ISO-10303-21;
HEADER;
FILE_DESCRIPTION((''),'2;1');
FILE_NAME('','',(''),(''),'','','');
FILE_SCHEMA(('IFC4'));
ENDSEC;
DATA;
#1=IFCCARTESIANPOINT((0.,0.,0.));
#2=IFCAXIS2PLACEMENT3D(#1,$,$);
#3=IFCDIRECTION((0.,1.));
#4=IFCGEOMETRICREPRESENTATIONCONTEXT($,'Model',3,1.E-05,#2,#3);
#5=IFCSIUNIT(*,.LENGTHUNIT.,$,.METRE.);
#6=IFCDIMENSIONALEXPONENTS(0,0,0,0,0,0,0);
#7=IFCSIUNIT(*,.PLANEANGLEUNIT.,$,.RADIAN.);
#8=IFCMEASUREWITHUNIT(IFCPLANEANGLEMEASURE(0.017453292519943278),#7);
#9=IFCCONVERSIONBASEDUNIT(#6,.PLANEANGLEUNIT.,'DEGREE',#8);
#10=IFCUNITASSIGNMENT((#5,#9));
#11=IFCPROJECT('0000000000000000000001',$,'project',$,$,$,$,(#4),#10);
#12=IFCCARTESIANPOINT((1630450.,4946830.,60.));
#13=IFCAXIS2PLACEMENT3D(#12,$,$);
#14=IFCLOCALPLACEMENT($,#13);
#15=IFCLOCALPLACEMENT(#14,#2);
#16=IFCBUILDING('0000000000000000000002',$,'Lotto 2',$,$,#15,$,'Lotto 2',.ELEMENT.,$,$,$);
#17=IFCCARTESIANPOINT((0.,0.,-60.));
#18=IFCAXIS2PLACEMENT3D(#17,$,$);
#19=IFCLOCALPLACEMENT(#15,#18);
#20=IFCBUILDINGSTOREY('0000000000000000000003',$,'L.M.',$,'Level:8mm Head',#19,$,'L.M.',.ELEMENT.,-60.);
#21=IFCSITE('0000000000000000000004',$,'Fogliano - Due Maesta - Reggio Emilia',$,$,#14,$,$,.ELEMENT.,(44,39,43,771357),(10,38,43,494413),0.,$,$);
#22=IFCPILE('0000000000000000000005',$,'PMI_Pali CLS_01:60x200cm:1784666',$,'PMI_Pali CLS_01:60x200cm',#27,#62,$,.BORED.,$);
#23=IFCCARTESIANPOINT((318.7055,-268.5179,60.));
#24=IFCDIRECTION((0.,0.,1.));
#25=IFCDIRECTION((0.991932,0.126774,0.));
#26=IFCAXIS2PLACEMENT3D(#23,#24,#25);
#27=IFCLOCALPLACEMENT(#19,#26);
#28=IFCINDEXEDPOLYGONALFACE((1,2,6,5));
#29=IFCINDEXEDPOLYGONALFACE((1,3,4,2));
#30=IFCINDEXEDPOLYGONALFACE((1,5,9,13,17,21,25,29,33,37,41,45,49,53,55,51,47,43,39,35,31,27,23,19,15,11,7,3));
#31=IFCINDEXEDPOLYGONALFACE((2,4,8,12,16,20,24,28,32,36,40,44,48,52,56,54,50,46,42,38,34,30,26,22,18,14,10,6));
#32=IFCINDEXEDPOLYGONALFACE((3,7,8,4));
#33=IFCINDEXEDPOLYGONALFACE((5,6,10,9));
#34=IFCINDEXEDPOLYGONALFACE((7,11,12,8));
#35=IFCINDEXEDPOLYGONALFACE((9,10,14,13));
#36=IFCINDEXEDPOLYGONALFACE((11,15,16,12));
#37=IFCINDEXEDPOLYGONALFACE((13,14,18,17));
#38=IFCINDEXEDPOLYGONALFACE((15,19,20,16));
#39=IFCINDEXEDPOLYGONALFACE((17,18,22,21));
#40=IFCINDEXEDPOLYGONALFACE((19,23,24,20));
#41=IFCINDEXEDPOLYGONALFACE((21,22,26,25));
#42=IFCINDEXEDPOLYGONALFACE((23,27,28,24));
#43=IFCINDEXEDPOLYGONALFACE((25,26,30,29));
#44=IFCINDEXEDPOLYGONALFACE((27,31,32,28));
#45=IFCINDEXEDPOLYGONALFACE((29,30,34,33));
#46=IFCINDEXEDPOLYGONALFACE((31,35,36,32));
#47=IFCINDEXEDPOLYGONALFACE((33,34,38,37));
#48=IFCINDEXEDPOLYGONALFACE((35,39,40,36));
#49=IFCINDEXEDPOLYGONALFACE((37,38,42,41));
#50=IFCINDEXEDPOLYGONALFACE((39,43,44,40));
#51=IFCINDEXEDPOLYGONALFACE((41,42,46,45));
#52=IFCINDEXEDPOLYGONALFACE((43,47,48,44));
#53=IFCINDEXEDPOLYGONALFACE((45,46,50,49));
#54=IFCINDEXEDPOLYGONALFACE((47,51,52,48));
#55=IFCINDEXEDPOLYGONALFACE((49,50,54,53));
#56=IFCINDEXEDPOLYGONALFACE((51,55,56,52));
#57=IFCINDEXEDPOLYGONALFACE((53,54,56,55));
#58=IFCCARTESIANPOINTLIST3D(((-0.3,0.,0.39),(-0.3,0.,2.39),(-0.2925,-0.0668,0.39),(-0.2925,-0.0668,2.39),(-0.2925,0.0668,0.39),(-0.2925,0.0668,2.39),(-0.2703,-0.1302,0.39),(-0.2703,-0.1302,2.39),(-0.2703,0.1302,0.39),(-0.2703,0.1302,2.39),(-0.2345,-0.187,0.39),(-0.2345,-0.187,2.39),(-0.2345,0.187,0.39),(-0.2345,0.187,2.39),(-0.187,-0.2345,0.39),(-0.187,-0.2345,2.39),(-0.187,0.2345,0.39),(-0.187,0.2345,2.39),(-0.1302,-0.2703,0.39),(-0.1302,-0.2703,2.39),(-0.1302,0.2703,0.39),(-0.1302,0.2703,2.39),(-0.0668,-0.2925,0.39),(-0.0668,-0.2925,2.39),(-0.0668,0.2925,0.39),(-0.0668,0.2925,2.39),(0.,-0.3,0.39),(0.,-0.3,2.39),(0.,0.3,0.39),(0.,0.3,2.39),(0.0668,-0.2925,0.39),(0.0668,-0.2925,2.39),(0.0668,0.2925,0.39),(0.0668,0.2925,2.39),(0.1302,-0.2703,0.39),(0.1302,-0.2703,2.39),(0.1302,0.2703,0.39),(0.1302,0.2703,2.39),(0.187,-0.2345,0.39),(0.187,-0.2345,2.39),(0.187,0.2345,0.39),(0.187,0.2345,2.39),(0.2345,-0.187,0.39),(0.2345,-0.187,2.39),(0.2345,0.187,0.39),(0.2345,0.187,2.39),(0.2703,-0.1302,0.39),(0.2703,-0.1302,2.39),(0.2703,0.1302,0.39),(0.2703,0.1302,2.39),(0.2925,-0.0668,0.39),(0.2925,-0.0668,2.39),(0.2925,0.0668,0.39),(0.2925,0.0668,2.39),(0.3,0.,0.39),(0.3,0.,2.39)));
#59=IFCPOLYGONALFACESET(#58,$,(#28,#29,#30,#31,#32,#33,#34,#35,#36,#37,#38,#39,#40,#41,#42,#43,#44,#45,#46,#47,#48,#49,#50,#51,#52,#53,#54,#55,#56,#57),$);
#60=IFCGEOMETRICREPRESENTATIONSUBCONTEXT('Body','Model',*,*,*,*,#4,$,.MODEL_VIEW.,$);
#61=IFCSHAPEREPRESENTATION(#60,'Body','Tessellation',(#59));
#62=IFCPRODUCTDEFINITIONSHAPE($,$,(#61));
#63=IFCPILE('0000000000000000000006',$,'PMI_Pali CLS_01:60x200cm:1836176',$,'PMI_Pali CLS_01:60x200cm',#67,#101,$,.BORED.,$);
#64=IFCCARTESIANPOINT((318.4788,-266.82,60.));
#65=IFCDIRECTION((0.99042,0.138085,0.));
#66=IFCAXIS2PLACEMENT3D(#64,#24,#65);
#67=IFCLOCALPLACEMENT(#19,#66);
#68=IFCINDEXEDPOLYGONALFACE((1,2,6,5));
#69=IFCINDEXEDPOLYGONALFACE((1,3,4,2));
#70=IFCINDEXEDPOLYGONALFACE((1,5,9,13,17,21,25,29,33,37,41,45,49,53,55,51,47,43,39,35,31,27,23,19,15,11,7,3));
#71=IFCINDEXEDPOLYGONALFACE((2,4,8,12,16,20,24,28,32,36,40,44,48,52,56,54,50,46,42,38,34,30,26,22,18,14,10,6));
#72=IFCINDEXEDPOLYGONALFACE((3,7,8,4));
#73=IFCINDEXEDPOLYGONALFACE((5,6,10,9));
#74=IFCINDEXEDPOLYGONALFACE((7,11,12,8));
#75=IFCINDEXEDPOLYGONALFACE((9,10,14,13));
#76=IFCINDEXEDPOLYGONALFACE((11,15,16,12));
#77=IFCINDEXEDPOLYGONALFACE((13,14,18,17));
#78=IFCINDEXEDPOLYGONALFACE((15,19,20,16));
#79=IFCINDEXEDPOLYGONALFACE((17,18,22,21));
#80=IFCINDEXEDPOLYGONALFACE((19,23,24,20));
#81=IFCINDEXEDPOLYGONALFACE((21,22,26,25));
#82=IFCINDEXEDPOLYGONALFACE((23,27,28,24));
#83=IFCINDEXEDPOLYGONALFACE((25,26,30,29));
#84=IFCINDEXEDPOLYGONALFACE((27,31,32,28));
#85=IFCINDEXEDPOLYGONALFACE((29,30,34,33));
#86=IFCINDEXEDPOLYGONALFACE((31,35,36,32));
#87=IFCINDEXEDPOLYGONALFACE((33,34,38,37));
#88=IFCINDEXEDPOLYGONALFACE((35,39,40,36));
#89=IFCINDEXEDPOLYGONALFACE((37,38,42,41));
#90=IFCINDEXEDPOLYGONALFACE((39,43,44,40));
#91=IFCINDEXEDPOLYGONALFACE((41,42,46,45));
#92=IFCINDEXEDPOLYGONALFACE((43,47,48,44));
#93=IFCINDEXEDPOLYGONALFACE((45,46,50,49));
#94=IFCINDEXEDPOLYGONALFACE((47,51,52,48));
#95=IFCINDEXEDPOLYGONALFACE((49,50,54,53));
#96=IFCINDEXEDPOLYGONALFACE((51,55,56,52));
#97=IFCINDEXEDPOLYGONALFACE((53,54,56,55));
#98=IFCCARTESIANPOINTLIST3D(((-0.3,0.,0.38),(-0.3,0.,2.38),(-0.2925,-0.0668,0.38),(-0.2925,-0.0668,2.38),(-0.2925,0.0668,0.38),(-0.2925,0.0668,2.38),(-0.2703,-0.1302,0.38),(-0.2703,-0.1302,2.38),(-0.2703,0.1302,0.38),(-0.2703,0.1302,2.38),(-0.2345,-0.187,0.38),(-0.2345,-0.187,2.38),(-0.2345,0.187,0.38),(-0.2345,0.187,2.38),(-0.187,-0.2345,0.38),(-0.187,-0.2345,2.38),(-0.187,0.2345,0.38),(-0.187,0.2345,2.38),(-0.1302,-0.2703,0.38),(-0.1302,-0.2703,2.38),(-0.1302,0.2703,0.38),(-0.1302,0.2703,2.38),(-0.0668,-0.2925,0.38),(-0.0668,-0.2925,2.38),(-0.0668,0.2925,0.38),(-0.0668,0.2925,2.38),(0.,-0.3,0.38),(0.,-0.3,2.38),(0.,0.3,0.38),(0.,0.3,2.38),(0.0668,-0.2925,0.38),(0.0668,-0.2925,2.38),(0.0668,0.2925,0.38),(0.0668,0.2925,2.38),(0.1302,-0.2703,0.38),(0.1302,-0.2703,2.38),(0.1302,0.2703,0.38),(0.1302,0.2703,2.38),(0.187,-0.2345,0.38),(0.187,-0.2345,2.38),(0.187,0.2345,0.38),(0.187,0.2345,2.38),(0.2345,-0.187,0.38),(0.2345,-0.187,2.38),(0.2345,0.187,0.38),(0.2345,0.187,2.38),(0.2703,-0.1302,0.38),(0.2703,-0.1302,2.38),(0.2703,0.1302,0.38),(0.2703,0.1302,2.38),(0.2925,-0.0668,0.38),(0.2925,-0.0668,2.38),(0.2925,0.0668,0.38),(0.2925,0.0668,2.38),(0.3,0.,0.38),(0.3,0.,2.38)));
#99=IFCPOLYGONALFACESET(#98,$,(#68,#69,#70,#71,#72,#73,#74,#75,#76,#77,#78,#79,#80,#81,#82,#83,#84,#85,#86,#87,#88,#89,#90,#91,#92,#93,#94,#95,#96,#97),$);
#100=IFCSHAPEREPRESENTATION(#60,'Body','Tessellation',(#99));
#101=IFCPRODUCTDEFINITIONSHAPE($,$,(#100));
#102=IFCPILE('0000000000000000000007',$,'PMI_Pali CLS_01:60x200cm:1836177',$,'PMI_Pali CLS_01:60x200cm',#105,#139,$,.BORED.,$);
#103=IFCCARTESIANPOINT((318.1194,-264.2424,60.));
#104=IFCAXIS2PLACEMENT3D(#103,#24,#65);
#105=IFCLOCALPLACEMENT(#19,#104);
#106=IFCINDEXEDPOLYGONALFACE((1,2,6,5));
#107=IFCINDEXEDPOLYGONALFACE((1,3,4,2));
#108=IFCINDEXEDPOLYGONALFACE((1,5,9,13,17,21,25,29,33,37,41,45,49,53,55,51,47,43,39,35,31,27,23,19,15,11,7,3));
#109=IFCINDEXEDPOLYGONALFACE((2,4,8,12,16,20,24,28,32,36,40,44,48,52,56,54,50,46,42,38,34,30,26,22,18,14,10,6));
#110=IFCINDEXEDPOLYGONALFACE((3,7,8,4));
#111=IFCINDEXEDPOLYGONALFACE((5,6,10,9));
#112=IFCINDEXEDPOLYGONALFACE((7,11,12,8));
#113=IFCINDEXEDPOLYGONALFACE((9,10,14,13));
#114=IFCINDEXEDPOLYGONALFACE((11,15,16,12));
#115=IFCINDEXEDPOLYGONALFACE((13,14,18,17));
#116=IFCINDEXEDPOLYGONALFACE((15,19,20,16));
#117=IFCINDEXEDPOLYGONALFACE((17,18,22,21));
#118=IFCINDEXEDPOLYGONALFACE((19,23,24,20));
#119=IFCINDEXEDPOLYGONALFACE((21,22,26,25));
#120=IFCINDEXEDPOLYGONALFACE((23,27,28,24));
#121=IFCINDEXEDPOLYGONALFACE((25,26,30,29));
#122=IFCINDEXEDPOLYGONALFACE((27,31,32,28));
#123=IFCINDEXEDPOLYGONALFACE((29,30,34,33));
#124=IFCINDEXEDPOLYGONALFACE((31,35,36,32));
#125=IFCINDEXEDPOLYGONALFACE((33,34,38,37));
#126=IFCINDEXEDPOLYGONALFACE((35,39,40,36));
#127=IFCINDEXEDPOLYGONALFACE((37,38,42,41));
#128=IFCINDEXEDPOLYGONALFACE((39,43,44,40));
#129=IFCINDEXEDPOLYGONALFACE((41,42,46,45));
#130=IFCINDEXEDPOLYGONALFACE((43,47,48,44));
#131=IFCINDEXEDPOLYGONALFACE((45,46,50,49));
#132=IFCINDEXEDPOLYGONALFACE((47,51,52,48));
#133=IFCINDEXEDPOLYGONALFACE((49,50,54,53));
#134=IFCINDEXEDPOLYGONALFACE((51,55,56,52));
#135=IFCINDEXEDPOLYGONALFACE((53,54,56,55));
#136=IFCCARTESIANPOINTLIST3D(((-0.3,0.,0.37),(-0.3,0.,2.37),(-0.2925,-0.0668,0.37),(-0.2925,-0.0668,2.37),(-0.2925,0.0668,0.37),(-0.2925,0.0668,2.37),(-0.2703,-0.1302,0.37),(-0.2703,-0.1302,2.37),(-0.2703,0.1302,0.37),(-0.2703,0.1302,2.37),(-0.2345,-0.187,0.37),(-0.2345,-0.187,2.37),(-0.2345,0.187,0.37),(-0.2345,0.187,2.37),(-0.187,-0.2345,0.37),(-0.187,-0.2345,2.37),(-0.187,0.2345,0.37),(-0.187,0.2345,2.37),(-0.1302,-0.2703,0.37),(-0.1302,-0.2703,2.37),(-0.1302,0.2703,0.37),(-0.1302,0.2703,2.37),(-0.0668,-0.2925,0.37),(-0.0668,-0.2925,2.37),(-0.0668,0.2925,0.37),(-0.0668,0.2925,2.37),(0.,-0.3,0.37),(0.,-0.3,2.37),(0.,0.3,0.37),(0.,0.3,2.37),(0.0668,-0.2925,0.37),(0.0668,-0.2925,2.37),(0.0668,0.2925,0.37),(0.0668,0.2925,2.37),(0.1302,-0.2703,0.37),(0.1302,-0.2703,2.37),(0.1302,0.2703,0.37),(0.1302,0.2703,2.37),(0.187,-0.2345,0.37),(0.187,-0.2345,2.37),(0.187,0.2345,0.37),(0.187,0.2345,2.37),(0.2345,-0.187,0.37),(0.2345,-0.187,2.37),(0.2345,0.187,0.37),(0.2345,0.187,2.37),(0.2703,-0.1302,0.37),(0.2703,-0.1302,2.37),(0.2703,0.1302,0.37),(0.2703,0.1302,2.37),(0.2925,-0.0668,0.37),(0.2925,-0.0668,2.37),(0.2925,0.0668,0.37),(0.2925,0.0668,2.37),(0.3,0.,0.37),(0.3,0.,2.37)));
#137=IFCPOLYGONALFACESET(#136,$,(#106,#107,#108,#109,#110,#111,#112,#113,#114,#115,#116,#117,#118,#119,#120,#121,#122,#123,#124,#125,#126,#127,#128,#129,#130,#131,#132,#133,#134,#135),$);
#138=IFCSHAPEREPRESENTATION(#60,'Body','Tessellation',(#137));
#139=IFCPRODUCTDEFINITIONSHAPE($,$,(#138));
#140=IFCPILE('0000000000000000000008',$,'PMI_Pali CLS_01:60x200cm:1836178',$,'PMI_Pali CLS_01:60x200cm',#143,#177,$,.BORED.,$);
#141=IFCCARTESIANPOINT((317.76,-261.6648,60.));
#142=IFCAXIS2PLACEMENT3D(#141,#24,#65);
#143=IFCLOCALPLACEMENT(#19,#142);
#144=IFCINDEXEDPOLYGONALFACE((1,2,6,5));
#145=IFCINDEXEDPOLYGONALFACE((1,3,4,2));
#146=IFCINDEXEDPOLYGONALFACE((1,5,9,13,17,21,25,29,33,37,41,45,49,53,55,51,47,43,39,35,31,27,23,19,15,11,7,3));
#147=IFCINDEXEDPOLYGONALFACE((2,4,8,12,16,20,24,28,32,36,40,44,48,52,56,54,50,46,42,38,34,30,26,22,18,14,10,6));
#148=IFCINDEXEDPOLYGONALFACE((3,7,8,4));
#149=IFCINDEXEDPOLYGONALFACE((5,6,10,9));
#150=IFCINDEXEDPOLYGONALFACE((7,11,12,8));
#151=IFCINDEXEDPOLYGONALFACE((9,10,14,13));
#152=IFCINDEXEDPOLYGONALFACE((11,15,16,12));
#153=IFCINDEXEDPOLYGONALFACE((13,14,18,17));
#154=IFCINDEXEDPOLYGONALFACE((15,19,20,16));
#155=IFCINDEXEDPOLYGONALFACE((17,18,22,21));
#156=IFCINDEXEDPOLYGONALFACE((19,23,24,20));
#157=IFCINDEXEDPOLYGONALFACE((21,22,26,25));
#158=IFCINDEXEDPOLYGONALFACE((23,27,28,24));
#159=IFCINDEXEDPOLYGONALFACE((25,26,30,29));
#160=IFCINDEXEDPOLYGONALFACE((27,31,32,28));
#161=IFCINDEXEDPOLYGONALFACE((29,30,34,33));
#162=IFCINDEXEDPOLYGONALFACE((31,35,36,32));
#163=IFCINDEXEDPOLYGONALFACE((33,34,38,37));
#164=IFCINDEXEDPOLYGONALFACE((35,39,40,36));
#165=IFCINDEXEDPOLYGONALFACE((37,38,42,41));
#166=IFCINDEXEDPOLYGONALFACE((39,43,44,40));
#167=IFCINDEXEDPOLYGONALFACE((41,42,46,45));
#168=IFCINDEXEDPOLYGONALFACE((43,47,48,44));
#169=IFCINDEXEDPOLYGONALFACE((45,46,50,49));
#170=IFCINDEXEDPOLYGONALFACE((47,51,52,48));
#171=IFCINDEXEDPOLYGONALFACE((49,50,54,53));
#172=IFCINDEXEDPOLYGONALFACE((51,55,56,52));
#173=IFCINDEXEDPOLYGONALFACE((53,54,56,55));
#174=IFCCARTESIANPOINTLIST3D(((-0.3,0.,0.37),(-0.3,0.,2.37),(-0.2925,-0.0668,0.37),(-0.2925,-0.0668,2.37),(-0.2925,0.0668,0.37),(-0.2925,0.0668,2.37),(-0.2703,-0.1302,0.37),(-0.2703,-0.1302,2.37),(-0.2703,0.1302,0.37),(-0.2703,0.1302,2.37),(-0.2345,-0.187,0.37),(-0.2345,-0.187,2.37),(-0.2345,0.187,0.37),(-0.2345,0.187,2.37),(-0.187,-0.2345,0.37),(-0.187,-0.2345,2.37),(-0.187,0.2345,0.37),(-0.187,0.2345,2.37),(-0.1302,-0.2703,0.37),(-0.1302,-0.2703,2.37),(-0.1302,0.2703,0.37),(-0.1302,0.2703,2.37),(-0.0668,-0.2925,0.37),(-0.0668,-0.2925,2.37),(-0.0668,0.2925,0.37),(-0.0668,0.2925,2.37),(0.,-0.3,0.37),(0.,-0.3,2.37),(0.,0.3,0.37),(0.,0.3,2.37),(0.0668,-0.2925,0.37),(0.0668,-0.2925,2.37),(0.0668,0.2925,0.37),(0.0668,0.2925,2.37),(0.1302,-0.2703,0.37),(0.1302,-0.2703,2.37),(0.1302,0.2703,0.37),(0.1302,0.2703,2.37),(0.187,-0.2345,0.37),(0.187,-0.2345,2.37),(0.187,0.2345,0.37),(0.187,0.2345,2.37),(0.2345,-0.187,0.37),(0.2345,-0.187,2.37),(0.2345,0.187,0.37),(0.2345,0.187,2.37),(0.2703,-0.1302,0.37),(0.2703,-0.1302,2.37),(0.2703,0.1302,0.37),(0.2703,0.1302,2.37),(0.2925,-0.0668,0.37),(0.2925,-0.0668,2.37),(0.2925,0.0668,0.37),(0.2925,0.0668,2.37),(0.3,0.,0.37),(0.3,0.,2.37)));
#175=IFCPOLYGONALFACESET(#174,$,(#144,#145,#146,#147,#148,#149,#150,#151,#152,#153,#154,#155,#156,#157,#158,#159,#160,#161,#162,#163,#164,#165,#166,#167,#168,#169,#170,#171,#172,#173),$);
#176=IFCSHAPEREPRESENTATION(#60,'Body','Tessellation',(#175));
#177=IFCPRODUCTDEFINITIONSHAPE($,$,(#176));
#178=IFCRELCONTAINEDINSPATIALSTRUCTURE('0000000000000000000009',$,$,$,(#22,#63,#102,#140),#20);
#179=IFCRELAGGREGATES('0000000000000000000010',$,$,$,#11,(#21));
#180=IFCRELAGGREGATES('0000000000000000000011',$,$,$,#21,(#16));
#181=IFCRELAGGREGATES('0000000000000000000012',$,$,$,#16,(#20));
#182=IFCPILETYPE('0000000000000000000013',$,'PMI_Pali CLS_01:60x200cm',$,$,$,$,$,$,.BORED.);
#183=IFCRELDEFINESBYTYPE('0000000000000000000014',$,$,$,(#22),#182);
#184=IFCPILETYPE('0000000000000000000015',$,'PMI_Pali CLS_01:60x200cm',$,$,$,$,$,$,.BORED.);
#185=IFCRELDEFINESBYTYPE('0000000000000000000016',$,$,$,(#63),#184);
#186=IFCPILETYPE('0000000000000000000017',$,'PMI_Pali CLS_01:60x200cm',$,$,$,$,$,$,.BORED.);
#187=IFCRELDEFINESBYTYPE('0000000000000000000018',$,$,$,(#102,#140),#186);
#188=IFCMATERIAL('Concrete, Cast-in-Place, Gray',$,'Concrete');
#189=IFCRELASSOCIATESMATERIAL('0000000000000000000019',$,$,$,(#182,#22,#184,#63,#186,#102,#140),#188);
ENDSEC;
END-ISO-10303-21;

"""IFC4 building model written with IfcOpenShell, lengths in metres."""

from ifc_helpers import new_model, entity, si_unit, converted_unit, direction, frame, origin, place, context, subcontext, project, spatial, arc, indexed_curve, outline, extrude, source, transform, mapped, material, type_object, type_shapes, element, save


model = new_model("IFC4")

# Units and contexts
model_context = context("Model", 3, precision=1e-05, world=origin(), true_north=direction((0.0, 1.0)))
body_context = subcontext(model_context, "Body", "Model", "MODEL_VIEW")
ifc_project = project(units=[si_unit("LENGTHUNIT", "METRE"), converted_unit("PLANEANGLEUNIT", "DEGREE", entity("IfcPlaneAngleMeasure", 0.017453292519943278), si_unit("PLANEANGLEUNIT", "RADIAN"), dimensions=[0, 0, 0, 0, 0, 0, 0])], contexts=[model_context])

# Site, building, storey
site_placement = place(None, frame((1630450.0, 4946830.0, 60.0)))
site = spatial("IfcSite", under=ifc_project, at=site_placement, Name="Fogliano - Due Maesta - Reggio Emilia", CompositionType="ELEMENT", RefLatitude=(44, 39, 43, 771357), RefLongitude=(10, 38, 43, 494413), RefElevation=0.0)
building_placement = place(site_placement, origin())
building = spatial("IfcBuilding", under=site, at=building_placement, Name="Lotto 2", LongName="Lotto 2", CompositionType="ELEMENT")
storey_placement = place(building_placement, frame((0.0, 0.0, -60.0)))
storey = spatial("IfcBuildingStorey", under=building, at=storey_placement, Name="L.M.", ObjectType="Level:8mm Head", LongName="L.M.", CompositionType="ELEMENT", Elevation=-60.0)

# Piles
ifc_material_1 = material(Name="Concrete, Cast-in-Place, Gray", Category="Concrete")
pile_type_1 = type_object("IfcPileType", Name="PMI_Pali CLS_01:60x200cm", PredefinedType="BORED", material=ifc_material_1)
shared_shape_1 = source(origin(), body_context, "Body", "SweptSolid", [
    extrude(outline(indexed_curve([(-0.3, 0.0), (0.0, -0.3), (0.3, 0.0), (0.0, 0.3)], segments=[arc(1, 2, 3), arc(3, 4, 1)], self_intersect=False)), frame((0.0, 0.0, 0.39)), (0.0, 0.0, 1.0), 2.0),
])
type_shapes(pile_type_1, [shared_shape_1])
pile_1_placement = place(storey_placement, frame((318.7055, -268.5179, 60.0), z_axis=(0.0, 0.0, 1.0), x_axis=(0.991932, 0.126774, 0.0)))
element("IfcPile", 1, at=pile_1_placement, inside=storey, type_object=pile_type_1, material=ifc_material_1, Name="PMI_Pali CLS_01:60x200cm:1784666", ObjectType="PMI_Pali CLS_01:60x200cm", PredefinedType="BORED", context=body_context, shape_type="MappedRepresentation", body=[
    mapped(shared_shape_1, transform((0.0, 0.0, 0.0), scale=1.0)),
])
pile_type_2 = type_object("IfcPileType", Name="PMI_Pali CLS_01:60x200cm", PredefinedType="BORED", material=ifc_material_1)
shared_shape_2 = source(origin(), body_context, "Body", "SweptSolid", [
    extrude(outline(indexed_curve([(-0.3, 0.0), (0.0, -0.3), (0.3, 0.0), (0.0, 0.3)], segments=[arc(1, 2, 3), arc(3, 4, 1)], self_intersect=False)), frame((0.0, 0.0, 0.38)), (0.0, 0.0, 1.0), 2.0),
])
type_shapes(pile_type_2, [shared_shape_2])
pile_2_placement = place(storey_placement, frame((318.4788, -266.82, 60.0), z_axis=(0.0, 0.0, 1.0), x_axis=(0.99042, 0.138085, 0.0)))
element("IfcPile", 2, at=pile_2_placement, inside=storey, type_object=pile_type_2, material=ifc_material_1, Name="PMI_Pali CLS_01:60x200cm:1836176", ObjectType="PMI_Pali CLS_01:60x200cm", PredefinedType="BORED", context=body_context, shape_type="MappedRepresentation", body=[
    mapped(shared_shape_2, transform((0.0, 0.0, 0.0), scale=1.0)),
])
pile_type_3 = type_object("IfcPileType", Name="PMI_Pali CLS_01:60x200cm", PredefinedType="BORED", material=ifc_material_1)
shared_shape_3 = source(origin(), body_context, "Body", "SweptSolid", [
    extrude(outline(indexed_curve([(-0.3, 0.0), (0.0, -0.3), (0.3, 0.0), (0.0, 0.3)], segments=[arc(1, 2, 3), arc(3, 4, 1)], self_intersect=False)), frame((0.0, 0.0, 0.37)), (0.0, 0.0, 1.0), 2.0),
])
type_shapes(pile_type_3, [shared_shape_3])
for number, where, z_axis, x_axis, name in (
    (3, (318.1194, -264.2424, 60.0), (0.0, 0.0, 1.0), (0.99042, 0.138085, 0.0), "PMI_Pali CLS_01:60x200cm:1836177"),
    (4, (317.76, -261.6648, 60.0), (0.0, 0.0, 1.0), (0.99042, 0.138085, 0.0), "PMI_Pali CLS_01:60x200cm:1836178"),
):
    element("IfcPile", number, at=place(storey_placement, frame(where, z_axis=z_axis, x_axis=x_axis)), inside=storey, type_object=pile_type_3, material=ifc_material_1, Name=name, ObjectType="PMI_Pali CLS_01:60x200cm", PredefinedType="BORED", context=body_context, shape_type="MappedRepresentation", body=[
        mapped(shared_shape_3, transform((0.0, 0.0, 0.0), scale=1.0)),
    ])

save(model, "model.ifc")
